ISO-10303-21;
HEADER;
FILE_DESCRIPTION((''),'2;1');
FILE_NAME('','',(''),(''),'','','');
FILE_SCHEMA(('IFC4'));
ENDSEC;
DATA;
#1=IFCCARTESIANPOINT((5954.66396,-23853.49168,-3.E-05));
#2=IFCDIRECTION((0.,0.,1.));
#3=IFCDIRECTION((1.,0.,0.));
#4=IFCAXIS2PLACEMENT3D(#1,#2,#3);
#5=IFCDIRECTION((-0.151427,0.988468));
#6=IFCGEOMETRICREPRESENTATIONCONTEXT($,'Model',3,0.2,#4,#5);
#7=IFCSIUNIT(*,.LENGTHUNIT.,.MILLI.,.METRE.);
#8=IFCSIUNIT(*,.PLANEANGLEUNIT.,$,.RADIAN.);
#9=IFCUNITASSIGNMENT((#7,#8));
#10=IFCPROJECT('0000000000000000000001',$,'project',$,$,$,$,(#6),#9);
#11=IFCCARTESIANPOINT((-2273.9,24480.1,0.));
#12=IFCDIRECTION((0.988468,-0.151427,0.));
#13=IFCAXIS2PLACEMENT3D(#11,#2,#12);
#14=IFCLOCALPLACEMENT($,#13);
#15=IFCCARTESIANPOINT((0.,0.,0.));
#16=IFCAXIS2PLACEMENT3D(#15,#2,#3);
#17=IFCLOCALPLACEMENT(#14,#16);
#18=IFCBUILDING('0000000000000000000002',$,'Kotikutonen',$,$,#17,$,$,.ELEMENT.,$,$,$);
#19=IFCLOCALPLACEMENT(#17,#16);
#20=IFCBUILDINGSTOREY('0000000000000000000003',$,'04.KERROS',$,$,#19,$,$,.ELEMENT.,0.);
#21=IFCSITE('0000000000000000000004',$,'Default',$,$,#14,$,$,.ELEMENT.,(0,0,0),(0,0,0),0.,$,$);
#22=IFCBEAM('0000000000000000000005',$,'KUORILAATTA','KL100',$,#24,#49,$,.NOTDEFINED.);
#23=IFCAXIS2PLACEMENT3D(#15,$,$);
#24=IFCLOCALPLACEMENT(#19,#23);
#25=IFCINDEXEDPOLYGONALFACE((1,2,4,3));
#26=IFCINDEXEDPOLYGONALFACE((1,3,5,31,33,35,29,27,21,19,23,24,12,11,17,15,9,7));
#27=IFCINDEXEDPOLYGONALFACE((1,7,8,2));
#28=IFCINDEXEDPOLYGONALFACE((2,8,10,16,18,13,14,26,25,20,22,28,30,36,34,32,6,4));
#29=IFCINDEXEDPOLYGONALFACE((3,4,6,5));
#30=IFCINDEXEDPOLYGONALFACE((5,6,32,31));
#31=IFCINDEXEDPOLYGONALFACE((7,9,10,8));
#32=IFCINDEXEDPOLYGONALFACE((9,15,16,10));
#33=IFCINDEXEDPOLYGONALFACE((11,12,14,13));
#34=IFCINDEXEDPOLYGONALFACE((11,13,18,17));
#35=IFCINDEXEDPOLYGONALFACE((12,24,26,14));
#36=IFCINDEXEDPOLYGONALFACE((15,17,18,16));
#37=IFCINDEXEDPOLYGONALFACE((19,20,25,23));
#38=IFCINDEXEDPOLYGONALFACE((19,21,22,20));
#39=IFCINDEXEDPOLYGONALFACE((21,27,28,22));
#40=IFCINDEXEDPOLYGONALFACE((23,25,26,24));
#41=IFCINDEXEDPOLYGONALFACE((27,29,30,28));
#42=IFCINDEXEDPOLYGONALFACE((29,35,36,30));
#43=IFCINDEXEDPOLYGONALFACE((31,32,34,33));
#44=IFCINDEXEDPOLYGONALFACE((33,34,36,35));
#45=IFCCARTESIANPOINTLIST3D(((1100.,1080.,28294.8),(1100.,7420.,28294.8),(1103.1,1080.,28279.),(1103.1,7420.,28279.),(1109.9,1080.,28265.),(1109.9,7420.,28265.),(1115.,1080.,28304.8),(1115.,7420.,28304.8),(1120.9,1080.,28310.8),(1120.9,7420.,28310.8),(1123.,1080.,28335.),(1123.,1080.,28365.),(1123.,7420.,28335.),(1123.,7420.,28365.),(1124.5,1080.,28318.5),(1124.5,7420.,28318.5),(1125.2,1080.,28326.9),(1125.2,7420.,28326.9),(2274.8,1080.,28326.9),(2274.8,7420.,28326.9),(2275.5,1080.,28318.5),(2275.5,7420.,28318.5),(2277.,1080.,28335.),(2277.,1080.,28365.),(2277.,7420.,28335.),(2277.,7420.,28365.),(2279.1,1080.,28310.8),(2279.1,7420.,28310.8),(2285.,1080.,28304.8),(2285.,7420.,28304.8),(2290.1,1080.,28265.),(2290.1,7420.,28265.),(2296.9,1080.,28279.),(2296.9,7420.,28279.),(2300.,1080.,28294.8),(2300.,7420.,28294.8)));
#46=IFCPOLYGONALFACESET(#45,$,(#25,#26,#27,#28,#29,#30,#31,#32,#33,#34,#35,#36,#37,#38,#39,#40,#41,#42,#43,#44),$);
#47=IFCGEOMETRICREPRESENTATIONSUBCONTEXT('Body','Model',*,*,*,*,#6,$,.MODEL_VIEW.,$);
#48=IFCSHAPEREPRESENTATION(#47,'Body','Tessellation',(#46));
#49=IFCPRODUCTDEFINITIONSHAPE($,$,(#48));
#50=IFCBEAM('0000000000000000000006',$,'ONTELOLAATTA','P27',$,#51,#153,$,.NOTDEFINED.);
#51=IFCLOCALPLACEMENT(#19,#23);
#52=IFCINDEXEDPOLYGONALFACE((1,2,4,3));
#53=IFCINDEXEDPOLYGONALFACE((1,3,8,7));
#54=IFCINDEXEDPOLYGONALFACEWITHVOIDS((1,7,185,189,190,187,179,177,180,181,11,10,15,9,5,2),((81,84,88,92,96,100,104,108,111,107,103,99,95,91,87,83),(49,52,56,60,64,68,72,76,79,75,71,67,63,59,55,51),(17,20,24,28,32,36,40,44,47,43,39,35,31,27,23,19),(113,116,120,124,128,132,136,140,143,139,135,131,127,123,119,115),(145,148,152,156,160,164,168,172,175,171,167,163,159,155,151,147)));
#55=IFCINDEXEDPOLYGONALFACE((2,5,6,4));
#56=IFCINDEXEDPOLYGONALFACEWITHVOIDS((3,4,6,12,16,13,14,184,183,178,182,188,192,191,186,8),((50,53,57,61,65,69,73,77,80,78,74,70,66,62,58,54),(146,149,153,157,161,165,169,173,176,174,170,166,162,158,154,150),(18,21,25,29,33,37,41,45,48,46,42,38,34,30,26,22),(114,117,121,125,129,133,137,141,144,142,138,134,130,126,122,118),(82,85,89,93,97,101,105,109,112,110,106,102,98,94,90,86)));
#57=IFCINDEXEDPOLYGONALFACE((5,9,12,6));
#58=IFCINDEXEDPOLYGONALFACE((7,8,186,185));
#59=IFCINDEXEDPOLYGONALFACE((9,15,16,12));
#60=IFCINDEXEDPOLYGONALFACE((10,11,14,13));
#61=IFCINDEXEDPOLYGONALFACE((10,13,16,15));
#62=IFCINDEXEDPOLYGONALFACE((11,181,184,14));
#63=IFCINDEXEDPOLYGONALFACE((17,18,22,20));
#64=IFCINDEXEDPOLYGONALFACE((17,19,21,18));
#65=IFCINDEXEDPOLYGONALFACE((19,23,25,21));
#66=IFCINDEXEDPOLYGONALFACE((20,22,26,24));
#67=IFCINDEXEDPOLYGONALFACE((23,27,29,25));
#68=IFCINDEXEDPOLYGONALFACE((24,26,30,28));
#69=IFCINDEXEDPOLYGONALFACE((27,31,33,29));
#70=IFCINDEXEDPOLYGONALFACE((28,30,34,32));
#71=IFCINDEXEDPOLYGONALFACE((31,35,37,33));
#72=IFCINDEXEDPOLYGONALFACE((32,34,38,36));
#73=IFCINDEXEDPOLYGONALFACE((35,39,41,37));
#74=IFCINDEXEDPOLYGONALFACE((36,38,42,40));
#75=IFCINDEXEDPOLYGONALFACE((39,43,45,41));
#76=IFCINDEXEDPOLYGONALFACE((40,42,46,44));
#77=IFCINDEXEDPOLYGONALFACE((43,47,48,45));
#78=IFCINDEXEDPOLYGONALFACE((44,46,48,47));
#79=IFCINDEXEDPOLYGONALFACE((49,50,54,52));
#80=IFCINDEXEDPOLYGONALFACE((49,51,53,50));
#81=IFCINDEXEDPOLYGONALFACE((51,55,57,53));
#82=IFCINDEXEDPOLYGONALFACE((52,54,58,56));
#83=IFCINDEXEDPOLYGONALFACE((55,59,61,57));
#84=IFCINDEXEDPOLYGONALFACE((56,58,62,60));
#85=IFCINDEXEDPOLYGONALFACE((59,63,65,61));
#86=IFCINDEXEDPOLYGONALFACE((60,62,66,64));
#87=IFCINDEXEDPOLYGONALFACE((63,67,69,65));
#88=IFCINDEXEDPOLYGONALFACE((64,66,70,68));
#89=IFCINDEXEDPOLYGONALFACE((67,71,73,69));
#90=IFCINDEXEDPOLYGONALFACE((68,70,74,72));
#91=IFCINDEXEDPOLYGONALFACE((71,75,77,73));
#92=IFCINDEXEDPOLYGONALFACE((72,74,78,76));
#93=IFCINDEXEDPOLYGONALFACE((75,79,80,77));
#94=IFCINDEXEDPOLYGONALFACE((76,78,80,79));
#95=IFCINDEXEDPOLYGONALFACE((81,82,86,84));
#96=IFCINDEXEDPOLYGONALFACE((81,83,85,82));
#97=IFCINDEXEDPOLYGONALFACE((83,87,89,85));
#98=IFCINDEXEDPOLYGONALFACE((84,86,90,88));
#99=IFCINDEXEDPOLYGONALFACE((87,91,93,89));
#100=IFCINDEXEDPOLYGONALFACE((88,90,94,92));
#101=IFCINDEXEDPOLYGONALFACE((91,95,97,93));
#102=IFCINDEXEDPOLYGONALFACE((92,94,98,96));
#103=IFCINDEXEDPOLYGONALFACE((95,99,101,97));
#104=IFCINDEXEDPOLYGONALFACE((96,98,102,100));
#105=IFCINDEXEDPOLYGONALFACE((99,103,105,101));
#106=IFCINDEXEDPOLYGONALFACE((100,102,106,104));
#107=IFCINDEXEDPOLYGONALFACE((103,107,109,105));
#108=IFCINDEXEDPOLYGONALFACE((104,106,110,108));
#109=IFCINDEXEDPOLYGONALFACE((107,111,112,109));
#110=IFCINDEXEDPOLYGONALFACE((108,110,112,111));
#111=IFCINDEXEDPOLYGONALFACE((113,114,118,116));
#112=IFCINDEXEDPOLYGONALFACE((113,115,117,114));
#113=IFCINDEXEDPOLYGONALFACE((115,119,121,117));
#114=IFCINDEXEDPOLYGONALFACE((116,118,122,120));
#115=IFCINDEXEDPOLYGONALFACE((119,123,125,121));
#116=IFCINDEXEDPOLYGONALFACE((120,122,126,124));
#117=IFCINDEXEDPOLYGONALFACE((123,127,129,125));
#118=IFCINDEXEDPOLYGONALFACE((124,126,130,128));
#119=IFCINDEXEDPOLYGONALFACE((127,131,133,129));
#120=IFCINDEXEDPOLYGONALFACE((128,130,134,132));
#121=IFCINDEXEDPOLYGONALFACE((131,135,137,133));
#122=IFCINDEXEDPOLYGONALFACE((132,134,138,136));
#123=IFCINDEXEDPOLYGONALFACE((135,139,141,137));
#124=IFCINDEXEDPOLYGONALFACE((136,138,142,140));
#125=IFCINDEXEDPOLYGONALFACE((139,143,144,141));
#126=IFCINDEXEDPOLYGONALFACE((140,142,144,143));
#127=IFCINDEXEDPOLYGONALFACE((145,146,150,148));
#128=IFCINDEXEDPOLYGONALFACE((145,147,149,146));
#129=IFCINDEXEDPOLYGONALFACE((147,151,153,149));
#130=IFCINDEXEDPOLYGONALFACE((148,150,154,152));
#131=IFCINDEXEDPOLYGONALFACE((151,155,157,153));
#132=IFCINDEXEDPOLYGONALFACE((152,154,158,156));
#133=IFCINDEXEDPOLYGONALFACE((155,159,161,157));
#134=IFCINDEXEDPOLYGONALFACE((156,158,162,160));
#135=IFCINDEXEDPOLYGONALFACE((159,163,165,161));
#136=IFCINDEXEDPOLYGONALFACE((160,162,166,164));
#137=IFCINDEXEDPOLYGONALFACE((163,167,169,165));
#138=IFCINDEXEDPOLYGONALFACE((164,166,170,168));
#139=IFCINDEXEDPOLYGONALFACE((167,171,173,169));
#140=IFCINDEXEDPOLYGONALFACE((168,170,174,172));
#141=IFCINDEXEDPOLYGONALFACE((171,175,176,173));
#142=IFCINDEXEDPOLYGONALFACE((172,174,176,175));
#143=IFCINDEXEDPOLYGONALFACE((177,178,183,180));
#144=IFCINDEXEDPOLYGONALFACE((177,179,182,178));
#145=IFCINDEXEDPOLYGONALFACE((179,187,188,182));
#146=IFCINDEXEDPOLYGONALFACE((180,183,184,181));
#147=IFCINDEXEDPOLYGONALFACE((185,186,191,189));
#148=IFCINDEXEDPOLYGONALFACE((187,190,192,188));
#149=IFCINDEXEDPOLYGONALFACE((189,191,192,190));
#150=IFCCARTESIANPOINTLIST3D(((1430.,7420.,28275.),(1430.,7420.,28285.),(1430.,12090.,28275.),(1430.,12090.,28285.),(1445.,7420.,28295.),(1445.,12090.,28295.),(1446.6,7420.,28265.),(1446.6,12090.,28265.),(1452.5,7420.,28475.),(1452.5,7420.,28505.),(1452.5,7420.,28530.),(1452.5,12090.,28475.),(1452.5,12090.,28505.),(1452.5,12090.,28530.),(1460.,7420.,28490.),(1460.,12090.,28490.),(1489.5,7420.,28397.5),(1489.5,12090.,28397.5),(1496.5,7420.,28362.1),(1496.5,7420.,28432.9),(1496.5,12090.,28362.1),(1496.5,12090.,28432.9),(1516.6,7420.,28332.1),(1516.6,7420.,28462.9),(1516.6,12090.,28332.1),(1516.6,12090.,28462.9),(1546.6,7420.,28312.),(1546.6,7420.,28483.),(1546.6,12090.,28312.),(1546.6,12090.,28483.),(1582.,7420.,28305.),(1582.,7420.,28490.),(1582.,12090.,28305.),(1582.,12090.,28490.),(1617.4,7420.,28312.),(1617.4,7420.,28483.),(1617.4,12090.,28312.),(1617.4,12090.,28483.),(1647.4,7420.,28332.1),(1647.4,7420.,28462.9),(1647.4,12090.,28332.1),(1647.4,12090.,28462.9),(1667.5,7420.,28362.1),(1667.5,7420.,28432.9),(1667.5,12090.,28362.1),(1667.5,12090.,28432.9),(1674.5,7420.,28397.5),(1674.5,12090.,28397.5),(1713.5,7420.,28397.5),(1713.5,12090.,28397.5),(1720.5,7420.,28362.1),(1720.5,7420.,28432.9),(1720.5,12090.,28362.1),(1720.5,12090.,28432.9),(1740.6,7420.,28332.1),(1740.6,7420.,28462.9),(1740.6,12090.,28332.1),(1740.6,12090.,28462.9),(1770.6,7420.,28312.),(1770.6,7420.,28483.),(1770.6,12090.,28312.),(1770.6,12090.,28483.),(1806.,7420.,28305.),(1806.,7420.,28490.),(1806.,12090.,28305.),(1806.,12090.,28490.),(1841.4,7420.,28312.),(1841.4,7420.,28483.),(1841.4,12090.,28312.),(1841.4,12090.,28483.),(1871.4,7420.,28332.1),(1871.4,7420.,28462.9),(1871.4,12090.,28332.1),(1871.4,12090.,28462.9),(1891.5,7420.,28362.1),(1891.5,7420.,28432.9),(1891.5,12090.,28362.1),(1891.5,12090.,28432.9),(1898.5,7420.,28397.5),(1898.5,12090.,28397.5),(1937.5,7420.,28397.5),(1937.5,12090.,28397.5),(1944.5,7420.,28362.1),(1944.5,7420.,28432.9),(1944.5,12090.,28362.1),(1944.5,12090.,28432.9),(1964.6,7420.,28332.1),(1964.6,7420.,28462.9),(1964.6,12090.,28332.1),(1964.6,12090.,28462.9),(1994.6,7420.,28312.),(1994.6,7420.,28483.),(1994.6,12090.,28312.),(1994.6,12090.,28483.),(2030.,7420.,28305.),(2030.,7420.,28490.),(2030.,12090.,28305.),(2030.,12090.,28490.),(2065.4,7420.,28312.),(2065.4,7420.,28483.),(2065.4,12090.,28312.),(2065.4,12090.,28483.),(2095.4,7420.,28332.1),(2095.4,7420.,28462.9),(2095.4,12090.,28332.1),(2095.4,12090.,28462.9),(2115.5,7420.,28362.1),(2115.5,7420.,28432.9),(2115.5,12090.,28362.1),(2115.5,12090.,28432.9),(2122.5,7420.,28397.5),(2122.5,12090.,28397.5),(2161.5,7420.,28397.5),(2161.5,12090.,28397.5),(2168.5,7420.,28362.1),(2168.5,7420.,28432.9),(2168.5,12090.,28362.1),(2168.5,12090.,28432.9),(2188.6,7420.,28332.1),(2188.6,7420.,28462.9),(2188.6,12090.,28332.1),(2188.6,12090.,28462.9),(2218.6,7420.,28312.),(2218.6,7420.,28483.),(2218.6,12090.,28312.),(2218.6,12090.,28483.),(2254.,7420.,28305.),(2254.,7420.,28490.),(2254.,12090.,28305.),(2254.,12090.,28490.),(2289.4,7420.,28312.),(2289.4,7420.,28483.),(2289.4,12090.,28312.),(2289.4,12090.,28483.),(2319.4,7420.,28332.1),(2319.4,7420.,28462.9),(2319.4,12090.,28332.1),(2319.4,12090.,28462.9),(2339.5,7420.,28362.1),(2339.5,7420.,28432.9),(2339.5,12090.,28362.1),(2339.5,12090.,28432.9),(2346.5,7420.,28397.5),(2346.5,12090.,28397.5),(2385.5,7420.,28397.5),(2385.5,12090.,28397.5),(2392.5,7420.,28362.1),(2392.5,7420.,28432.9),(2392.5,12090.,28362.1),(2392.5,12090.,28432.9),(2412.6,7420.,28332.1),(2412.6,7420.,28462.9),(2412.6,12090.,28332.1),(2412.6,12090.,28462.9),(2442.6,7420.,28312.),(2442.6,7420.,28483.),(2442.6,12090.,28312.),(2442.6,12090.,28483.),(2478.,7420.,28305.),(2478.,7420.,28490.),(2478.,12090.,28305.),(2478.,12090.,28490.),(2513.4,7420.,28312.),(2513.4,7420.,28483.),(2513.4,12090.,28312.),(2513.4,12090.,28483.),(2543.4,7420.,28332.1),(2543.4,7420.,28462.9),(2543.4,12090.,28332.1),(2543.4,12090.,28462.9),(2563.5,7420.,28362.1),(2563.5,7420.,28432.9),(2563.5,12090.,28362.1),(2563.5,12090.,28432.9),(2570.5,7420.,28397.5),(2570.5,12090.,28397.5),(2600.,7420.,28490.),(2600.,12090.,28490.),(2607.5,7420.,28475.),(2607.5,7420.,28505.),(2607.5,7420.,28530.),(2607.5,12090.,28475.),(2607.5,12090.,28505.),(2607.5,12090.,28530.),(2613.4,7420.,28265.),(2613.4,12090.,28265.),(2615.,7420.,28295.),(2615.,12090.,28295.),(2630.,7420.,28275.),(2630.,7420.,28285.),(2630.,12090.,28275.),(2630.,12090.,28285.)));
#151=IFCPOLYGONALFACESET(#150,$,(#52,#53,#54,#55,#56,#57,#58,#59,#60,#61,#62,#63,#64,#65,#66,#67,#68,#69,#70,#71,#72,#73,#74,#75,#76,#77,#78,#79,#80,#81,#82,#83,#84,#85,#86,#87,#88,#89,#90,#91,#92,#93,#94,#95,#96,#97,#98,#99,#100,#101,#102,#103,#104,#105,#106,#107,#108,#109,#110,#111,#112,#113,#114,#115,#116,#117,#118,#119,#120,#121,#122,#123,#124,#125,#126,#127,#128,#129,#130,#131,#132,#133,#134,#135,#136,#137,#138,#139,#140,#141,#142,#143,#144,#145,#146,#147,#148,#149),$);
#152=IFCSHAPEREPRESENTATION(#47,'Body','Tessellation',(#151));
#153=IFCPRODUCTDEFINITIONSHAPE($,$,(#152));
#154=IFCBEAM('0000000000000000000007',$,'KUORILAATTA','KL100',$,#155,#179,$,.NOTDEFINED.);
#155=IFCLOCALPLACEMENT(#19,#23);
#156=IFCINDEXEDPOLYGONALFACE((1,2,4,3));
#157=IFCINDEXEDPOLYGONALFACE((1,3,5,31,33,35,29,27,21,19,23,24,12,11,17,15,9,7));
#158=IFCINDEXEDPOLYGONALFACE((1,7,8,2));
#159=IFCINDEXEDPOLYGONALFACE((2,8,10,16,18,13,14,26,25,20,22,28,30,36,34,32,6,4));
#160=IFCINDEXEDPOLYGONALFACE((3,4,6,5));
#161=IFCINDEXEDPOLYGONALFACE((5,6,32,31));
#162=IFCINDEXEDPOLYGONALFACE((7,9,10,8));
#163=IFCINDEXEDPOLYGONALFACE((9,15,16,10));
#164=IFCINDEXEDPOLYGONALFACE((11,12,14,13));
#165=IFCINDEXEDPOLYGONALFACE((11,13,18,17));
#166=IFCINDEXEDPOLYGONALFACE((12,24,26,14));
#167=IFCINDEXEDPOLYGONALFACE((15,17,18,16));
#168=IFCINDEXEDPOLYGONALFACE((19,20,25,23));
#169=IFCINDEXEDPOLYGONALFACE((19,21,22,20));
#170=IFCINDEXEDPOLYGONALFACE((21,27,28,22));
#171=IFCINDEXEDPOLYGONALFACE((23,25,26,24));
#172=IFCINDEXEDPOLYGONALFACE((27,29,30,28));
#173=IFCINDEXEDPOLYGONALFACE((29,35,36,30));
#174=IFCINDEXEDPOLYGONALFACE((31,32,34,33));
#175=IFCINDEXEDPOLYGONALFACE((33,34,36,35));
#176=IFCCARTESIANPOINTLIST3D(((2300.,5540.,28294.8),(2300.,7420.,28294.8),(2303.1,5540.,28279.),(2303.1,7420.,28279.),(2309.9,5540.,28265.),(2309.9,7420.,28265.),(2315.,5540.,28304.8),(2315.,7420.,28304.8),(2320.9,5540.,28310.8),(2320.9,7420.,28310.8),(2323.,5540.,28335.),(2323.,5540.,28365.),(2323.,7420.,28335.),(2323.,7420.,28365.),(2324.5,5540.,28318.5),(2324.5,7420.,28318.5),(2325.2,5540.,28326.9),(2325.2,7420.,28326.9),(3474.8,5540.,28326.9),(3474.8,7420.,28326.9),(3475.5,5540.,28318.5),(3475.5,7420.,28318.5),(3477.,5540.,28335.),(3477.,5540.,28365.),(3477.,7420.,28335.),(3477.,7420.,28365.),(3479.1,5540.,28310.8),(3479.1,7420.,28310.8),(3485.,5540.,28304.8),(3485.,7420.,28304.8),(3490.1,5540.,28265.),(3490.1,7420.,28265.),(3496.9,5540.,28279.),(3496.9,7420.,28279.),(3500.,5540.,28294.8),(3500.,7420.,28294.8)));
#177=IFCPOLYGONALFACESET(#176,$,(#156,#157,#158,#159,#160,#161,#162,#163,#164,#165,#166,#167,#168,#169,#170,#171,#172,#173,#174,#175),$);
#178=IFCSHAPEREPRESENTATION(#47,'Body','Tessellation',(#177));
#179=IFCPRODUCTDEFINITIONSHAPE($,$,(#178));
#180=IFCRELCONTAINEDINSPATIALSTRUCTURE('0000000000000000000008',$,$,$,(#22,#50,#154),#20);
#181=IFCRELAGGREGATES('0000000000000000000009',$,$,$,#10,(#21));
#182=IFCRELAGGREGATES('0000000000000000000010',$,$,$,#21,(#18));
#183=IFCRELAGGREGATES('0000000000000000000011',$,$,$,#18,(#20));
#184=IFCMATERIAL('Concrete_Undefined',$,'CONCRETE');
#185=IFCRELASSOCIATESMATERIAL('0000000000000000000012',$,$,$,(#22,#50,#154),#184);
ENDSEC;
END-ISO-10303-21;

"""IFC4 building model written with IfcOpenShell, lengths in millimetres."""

from ifc_helpers import new_model, si_unit, direction, frame, origin_with_axes, place, context, subcontext, project, spatial, line, indexed_curve, outline, extrude, material, element, save


model = new_model("IFC4")

# Units and contexts
model_context = context("Model", 3, precision=0.2, world=frame((5954.66396, -23853.49168, -3e-05), z_axis=(0.0, 0.0, 1.0), x_axis=(1.0, 0.0, 0.0)), true_north=direction((-0.151427, 0.988468)))
body_context = subcontext(model_context, "Body", "Model", "MODEL_VIEW")
ifc_project = project(units=[si_unit("LENGTHUNIT", "METRE", prefix="MILLI"), si_unit("PLANEANGLEUNIT", "RADIAN")], contexts=[model_context])

# Site, building, storey
site_placement = place(None, frame((-2273.9, 24480.1, 0.0), z_axis=(0.0, 0.0, 1.0), x_axis=(0.988468, -0.151427, 0.0)))
site = spatial("IfcSite", under=ifc_project, at=site_placement, Name="Default", CompositionType="ELEMENT", RefLatitude=(0, 0, 0), RefLongitude=(0, 0, 0), RefElevation=0.0)
building_placement = place(site_placement, origin_with_axes())
building = spatial("IfcBuilding", under=site, at=building_placement, Name="Kotikutonen", CompositionType="ELEMENT")
storey_placement = place(building_placement, origin_with_axes())
storey = spatial("IfcBuildingStorey", under=building, at=storey_placement, Name="04.KERROS", CompositionType="ELEMENT", Elevation=0.0)

# Shared definitions
ifc_material_1 = material(Name="Concrete_Undefined", Category="CONCRETE")

# Beams
beam_1_placement = place(storey_placement, frame((1700.0, 7420.0, 28315.0), z_axis=(-1.0, 0.0, 0.0), x_axis=(0.0, -1.0, 0.0)))
element("IfcBeam", 1, at=beam_1_placement, inside=storey, material=ifc_material_1, Name="KUORILAATTA", Description="KL100", PredefinedType="NOTDEFINED", context=body_context, shape_type="SolidModel", body=[
    extrude(outline(indexed_curve([(-596.9, -36.0), (-590.1, -50.0), (590.1, -50.0), (596.9, -36.0), (600.0, -20.2), (585.0, -10.2), (579.1, -4.2), (575.5, 3.5), (574.8, 11.9), (577.0, 20.0), (577.0, 50.0), (-577.0, 50.0), (-577.0, 20.0), (-574.8, 11.9), (-575.5, 3.5), (-579.1, -4.2), (-585.0, -10.2), (-600.0, -20.2)], segments=[line(1, 2, 3, 4, 5, 6, 7, 8, 9, 10, 11, 12, 13, 14, 15, 16, 17, 18, 1)])), frame((0.0, 0.0, 0.0), z_axis=(-1.0, 0.0, 0.0), x_axis=(0.0, 0.0, 1.0)), (0.0, 0.0, -1.0), 6340.0),
])
beam_2_placement = place(storey_placement, frame((2030.0, 12090.0, 28397.5), z_axis=(-1.0, 0.0, 0.0), x_axis=(0.0, -1.0, 0.0)))
element("IfcBeam", 2, at=beam_2_placement, inside=storey, material=ifc_material_1, Name="ONTELOLAATTA", Description="P27", PredefinedType="NOTDEFINED", context=body_context, shape_type="SolidModel", body=[
    extrude(outline(indexed_curve([(-600.0, -122.5), (-583.4, -132.5), (583.4, -132.5), (600.0, -122.5), (600.0, -112.5), (585.0, -102.5), (577.5, 77.5), (570.0, 92.5), (577.5, 107.5), (577.5, 132.5), (-577.5, 132.5), (-577.5, 107.5), (-570.0, 92.5), (-577.5, 77.5), (-585.0, -102.5), (-600.0, -112.5)], segments=[line(1, 2, 3, 4, 5, 6, 7, 8, 9, 10, 11, 12, 13, 14, 15, 16, 1)]), holes=[indexed_curve([(-448.0, -92.5), (-483.4, -85.5), (-513.4, -65.4), (-533.5, -35.4), (-540.5, 0.0), (-533.5, 35.4), (-513.4, 65.4), (-483.4, 85.5), (-448.0, 92.5), (-412.6, 85.5), (-382.6, 65.4), (-362.5, 35.4), (-355.5, 0.0), (-362.5, -35.4), (-382.6, -65.4), (-412.6, -85.5)], segments=[line(1, 2, 3, 4, 5, 6, 7, 8, 9, 10, 11, 12, 13, 14, 15, 16, 1)]), indexed_curve([(-224.0, -92.5), (-259.4, -85.5), (-289.4, -65.4), (-309.5, -35.4), (-316.5, 0.0), (-309.5, 35.4), (-289.4, 65.4), (-259.4, 85.5), (-224.0, 92.5), (-188.6, 85.5), (-158.6, 65.4), (-138.5, 35.4), (-131.5, 0.0), (-138.5, -35.4), (-158.6, -65.4), (-188.6, -85.5)], segments=[line(1, 2, 3, 4, 5, 6, 7, 8, 9, 10, 11, 12, 13, 14, 15, 16, 1)]), indexed_curve([(0.0, -92.5), (-35.4, -85.5), (-65.4, -65.4), (-85.5, -35.4), (-92.5, 0.0), (-85.5, 35.4), (-65.4, 65.4), (-35.4, 85.5), (0.0, 92.5), (35.4, 85.5), (65.4, 65.4), (85.5, 35.4), (92.5, 0.0), (85.5, -35.4), (65.4, -65.4), (35.4, -85.5)], segments=[line(1, 2, 3, 4, 5, 6, 7, 8, 9, 10, 11, 12, 13, 14, 15, 16, 1)]), indexed_curve([(224.0, -92.5), (188.6, -85.5), (158.6, -65.4), (138.5, -35.4), (131.5, 0.0), (138.5, 35.4), (158.6, 65.4), (188.6, 85.5), (224.0, 92.5), (259.4, 85.5), (289.4, 65.4), (309.5, 35.4), (316.5, 0.0), (309.5, -35.4), (289.4, -65.4), (259.4, -85.5)], segments=[line(1, 2, 3, 4, 5, 6, 7, 8, 9, 10, 11, 12, 13, 14, 15, 16, 1)]), indexed_curve([(448.0, -92.5), (412.6, -85.5), (382.6, -65.4), (362.5, -35.4), (355.5, 0.0), (362.5, 35.4), (382.6, 65.4), (412.6, 85.5), (448.0, 92.5), (483.4, 85.5), (513.4, 65.4), (533.5, 35.4), (540.5, 0.0), (533.5, -35.4), (513.4, -65.4), (483.4, -85.5)], segments=[line(1, 2, 3, 4, 5, 6, 7, 8, 9, 10, 11, 12, 13, 14, 15, 16, 1)])]), frame((0.0, 0.0, 0.0), z_axis=(-1.0, 0.0, 0.0), x_axis=(0.0, 0.0, 1.0)), (0.0, 0.0, -1.0), 4670.0),
])
beam_3_placement = place(storey_placement, frame((2900.0, 7420.0, 28315.0), z_axis=(-1.0, 0.0, 0.0), x_axis=(0.0, -1.0, 0.0)))
element("IfcBeam", 3, at=beam_3_placement, inside=storey, material=ifc_material_1, Name="KUORILAATTA", Description="KL100", PredefinedType="NOTDEFINED", context=body_context, shape_type="SolidModel", body=[
    extrude(outline(indexed_curve([(-596.9, -36.0), (-590.1, -50.0), (590.1, -50.0), (596.9, -36.0), (600.0, -20.2), (585.0, -10.2), (579.1, -4.2), (575.5, 3.5), (574.8, 11.9), (577.0, 20.0), (577.0, 50.0), (-577.0, 50.0), (-577.0, 20.0), (-574.8, 11.9), (-575.5, 3.5), (-579.1, -4.2), (-585.0, -10.2), (-600.0, -20.2)], segments=[line(1, 2, 3, 4, 5, 6, 7, 8, 9, 10, 11, 12, 13, 14, 15, 16, 17, 18, 1)])), frame((0.0, 0.0, 0.0), z_axis=(-1.0, 0.0, 0.0), x_axis=(0.0, 0.0, 1.0)), (0.0, 0.0, -1.0), 1880.0),
])

save(model, "model.ifc")
